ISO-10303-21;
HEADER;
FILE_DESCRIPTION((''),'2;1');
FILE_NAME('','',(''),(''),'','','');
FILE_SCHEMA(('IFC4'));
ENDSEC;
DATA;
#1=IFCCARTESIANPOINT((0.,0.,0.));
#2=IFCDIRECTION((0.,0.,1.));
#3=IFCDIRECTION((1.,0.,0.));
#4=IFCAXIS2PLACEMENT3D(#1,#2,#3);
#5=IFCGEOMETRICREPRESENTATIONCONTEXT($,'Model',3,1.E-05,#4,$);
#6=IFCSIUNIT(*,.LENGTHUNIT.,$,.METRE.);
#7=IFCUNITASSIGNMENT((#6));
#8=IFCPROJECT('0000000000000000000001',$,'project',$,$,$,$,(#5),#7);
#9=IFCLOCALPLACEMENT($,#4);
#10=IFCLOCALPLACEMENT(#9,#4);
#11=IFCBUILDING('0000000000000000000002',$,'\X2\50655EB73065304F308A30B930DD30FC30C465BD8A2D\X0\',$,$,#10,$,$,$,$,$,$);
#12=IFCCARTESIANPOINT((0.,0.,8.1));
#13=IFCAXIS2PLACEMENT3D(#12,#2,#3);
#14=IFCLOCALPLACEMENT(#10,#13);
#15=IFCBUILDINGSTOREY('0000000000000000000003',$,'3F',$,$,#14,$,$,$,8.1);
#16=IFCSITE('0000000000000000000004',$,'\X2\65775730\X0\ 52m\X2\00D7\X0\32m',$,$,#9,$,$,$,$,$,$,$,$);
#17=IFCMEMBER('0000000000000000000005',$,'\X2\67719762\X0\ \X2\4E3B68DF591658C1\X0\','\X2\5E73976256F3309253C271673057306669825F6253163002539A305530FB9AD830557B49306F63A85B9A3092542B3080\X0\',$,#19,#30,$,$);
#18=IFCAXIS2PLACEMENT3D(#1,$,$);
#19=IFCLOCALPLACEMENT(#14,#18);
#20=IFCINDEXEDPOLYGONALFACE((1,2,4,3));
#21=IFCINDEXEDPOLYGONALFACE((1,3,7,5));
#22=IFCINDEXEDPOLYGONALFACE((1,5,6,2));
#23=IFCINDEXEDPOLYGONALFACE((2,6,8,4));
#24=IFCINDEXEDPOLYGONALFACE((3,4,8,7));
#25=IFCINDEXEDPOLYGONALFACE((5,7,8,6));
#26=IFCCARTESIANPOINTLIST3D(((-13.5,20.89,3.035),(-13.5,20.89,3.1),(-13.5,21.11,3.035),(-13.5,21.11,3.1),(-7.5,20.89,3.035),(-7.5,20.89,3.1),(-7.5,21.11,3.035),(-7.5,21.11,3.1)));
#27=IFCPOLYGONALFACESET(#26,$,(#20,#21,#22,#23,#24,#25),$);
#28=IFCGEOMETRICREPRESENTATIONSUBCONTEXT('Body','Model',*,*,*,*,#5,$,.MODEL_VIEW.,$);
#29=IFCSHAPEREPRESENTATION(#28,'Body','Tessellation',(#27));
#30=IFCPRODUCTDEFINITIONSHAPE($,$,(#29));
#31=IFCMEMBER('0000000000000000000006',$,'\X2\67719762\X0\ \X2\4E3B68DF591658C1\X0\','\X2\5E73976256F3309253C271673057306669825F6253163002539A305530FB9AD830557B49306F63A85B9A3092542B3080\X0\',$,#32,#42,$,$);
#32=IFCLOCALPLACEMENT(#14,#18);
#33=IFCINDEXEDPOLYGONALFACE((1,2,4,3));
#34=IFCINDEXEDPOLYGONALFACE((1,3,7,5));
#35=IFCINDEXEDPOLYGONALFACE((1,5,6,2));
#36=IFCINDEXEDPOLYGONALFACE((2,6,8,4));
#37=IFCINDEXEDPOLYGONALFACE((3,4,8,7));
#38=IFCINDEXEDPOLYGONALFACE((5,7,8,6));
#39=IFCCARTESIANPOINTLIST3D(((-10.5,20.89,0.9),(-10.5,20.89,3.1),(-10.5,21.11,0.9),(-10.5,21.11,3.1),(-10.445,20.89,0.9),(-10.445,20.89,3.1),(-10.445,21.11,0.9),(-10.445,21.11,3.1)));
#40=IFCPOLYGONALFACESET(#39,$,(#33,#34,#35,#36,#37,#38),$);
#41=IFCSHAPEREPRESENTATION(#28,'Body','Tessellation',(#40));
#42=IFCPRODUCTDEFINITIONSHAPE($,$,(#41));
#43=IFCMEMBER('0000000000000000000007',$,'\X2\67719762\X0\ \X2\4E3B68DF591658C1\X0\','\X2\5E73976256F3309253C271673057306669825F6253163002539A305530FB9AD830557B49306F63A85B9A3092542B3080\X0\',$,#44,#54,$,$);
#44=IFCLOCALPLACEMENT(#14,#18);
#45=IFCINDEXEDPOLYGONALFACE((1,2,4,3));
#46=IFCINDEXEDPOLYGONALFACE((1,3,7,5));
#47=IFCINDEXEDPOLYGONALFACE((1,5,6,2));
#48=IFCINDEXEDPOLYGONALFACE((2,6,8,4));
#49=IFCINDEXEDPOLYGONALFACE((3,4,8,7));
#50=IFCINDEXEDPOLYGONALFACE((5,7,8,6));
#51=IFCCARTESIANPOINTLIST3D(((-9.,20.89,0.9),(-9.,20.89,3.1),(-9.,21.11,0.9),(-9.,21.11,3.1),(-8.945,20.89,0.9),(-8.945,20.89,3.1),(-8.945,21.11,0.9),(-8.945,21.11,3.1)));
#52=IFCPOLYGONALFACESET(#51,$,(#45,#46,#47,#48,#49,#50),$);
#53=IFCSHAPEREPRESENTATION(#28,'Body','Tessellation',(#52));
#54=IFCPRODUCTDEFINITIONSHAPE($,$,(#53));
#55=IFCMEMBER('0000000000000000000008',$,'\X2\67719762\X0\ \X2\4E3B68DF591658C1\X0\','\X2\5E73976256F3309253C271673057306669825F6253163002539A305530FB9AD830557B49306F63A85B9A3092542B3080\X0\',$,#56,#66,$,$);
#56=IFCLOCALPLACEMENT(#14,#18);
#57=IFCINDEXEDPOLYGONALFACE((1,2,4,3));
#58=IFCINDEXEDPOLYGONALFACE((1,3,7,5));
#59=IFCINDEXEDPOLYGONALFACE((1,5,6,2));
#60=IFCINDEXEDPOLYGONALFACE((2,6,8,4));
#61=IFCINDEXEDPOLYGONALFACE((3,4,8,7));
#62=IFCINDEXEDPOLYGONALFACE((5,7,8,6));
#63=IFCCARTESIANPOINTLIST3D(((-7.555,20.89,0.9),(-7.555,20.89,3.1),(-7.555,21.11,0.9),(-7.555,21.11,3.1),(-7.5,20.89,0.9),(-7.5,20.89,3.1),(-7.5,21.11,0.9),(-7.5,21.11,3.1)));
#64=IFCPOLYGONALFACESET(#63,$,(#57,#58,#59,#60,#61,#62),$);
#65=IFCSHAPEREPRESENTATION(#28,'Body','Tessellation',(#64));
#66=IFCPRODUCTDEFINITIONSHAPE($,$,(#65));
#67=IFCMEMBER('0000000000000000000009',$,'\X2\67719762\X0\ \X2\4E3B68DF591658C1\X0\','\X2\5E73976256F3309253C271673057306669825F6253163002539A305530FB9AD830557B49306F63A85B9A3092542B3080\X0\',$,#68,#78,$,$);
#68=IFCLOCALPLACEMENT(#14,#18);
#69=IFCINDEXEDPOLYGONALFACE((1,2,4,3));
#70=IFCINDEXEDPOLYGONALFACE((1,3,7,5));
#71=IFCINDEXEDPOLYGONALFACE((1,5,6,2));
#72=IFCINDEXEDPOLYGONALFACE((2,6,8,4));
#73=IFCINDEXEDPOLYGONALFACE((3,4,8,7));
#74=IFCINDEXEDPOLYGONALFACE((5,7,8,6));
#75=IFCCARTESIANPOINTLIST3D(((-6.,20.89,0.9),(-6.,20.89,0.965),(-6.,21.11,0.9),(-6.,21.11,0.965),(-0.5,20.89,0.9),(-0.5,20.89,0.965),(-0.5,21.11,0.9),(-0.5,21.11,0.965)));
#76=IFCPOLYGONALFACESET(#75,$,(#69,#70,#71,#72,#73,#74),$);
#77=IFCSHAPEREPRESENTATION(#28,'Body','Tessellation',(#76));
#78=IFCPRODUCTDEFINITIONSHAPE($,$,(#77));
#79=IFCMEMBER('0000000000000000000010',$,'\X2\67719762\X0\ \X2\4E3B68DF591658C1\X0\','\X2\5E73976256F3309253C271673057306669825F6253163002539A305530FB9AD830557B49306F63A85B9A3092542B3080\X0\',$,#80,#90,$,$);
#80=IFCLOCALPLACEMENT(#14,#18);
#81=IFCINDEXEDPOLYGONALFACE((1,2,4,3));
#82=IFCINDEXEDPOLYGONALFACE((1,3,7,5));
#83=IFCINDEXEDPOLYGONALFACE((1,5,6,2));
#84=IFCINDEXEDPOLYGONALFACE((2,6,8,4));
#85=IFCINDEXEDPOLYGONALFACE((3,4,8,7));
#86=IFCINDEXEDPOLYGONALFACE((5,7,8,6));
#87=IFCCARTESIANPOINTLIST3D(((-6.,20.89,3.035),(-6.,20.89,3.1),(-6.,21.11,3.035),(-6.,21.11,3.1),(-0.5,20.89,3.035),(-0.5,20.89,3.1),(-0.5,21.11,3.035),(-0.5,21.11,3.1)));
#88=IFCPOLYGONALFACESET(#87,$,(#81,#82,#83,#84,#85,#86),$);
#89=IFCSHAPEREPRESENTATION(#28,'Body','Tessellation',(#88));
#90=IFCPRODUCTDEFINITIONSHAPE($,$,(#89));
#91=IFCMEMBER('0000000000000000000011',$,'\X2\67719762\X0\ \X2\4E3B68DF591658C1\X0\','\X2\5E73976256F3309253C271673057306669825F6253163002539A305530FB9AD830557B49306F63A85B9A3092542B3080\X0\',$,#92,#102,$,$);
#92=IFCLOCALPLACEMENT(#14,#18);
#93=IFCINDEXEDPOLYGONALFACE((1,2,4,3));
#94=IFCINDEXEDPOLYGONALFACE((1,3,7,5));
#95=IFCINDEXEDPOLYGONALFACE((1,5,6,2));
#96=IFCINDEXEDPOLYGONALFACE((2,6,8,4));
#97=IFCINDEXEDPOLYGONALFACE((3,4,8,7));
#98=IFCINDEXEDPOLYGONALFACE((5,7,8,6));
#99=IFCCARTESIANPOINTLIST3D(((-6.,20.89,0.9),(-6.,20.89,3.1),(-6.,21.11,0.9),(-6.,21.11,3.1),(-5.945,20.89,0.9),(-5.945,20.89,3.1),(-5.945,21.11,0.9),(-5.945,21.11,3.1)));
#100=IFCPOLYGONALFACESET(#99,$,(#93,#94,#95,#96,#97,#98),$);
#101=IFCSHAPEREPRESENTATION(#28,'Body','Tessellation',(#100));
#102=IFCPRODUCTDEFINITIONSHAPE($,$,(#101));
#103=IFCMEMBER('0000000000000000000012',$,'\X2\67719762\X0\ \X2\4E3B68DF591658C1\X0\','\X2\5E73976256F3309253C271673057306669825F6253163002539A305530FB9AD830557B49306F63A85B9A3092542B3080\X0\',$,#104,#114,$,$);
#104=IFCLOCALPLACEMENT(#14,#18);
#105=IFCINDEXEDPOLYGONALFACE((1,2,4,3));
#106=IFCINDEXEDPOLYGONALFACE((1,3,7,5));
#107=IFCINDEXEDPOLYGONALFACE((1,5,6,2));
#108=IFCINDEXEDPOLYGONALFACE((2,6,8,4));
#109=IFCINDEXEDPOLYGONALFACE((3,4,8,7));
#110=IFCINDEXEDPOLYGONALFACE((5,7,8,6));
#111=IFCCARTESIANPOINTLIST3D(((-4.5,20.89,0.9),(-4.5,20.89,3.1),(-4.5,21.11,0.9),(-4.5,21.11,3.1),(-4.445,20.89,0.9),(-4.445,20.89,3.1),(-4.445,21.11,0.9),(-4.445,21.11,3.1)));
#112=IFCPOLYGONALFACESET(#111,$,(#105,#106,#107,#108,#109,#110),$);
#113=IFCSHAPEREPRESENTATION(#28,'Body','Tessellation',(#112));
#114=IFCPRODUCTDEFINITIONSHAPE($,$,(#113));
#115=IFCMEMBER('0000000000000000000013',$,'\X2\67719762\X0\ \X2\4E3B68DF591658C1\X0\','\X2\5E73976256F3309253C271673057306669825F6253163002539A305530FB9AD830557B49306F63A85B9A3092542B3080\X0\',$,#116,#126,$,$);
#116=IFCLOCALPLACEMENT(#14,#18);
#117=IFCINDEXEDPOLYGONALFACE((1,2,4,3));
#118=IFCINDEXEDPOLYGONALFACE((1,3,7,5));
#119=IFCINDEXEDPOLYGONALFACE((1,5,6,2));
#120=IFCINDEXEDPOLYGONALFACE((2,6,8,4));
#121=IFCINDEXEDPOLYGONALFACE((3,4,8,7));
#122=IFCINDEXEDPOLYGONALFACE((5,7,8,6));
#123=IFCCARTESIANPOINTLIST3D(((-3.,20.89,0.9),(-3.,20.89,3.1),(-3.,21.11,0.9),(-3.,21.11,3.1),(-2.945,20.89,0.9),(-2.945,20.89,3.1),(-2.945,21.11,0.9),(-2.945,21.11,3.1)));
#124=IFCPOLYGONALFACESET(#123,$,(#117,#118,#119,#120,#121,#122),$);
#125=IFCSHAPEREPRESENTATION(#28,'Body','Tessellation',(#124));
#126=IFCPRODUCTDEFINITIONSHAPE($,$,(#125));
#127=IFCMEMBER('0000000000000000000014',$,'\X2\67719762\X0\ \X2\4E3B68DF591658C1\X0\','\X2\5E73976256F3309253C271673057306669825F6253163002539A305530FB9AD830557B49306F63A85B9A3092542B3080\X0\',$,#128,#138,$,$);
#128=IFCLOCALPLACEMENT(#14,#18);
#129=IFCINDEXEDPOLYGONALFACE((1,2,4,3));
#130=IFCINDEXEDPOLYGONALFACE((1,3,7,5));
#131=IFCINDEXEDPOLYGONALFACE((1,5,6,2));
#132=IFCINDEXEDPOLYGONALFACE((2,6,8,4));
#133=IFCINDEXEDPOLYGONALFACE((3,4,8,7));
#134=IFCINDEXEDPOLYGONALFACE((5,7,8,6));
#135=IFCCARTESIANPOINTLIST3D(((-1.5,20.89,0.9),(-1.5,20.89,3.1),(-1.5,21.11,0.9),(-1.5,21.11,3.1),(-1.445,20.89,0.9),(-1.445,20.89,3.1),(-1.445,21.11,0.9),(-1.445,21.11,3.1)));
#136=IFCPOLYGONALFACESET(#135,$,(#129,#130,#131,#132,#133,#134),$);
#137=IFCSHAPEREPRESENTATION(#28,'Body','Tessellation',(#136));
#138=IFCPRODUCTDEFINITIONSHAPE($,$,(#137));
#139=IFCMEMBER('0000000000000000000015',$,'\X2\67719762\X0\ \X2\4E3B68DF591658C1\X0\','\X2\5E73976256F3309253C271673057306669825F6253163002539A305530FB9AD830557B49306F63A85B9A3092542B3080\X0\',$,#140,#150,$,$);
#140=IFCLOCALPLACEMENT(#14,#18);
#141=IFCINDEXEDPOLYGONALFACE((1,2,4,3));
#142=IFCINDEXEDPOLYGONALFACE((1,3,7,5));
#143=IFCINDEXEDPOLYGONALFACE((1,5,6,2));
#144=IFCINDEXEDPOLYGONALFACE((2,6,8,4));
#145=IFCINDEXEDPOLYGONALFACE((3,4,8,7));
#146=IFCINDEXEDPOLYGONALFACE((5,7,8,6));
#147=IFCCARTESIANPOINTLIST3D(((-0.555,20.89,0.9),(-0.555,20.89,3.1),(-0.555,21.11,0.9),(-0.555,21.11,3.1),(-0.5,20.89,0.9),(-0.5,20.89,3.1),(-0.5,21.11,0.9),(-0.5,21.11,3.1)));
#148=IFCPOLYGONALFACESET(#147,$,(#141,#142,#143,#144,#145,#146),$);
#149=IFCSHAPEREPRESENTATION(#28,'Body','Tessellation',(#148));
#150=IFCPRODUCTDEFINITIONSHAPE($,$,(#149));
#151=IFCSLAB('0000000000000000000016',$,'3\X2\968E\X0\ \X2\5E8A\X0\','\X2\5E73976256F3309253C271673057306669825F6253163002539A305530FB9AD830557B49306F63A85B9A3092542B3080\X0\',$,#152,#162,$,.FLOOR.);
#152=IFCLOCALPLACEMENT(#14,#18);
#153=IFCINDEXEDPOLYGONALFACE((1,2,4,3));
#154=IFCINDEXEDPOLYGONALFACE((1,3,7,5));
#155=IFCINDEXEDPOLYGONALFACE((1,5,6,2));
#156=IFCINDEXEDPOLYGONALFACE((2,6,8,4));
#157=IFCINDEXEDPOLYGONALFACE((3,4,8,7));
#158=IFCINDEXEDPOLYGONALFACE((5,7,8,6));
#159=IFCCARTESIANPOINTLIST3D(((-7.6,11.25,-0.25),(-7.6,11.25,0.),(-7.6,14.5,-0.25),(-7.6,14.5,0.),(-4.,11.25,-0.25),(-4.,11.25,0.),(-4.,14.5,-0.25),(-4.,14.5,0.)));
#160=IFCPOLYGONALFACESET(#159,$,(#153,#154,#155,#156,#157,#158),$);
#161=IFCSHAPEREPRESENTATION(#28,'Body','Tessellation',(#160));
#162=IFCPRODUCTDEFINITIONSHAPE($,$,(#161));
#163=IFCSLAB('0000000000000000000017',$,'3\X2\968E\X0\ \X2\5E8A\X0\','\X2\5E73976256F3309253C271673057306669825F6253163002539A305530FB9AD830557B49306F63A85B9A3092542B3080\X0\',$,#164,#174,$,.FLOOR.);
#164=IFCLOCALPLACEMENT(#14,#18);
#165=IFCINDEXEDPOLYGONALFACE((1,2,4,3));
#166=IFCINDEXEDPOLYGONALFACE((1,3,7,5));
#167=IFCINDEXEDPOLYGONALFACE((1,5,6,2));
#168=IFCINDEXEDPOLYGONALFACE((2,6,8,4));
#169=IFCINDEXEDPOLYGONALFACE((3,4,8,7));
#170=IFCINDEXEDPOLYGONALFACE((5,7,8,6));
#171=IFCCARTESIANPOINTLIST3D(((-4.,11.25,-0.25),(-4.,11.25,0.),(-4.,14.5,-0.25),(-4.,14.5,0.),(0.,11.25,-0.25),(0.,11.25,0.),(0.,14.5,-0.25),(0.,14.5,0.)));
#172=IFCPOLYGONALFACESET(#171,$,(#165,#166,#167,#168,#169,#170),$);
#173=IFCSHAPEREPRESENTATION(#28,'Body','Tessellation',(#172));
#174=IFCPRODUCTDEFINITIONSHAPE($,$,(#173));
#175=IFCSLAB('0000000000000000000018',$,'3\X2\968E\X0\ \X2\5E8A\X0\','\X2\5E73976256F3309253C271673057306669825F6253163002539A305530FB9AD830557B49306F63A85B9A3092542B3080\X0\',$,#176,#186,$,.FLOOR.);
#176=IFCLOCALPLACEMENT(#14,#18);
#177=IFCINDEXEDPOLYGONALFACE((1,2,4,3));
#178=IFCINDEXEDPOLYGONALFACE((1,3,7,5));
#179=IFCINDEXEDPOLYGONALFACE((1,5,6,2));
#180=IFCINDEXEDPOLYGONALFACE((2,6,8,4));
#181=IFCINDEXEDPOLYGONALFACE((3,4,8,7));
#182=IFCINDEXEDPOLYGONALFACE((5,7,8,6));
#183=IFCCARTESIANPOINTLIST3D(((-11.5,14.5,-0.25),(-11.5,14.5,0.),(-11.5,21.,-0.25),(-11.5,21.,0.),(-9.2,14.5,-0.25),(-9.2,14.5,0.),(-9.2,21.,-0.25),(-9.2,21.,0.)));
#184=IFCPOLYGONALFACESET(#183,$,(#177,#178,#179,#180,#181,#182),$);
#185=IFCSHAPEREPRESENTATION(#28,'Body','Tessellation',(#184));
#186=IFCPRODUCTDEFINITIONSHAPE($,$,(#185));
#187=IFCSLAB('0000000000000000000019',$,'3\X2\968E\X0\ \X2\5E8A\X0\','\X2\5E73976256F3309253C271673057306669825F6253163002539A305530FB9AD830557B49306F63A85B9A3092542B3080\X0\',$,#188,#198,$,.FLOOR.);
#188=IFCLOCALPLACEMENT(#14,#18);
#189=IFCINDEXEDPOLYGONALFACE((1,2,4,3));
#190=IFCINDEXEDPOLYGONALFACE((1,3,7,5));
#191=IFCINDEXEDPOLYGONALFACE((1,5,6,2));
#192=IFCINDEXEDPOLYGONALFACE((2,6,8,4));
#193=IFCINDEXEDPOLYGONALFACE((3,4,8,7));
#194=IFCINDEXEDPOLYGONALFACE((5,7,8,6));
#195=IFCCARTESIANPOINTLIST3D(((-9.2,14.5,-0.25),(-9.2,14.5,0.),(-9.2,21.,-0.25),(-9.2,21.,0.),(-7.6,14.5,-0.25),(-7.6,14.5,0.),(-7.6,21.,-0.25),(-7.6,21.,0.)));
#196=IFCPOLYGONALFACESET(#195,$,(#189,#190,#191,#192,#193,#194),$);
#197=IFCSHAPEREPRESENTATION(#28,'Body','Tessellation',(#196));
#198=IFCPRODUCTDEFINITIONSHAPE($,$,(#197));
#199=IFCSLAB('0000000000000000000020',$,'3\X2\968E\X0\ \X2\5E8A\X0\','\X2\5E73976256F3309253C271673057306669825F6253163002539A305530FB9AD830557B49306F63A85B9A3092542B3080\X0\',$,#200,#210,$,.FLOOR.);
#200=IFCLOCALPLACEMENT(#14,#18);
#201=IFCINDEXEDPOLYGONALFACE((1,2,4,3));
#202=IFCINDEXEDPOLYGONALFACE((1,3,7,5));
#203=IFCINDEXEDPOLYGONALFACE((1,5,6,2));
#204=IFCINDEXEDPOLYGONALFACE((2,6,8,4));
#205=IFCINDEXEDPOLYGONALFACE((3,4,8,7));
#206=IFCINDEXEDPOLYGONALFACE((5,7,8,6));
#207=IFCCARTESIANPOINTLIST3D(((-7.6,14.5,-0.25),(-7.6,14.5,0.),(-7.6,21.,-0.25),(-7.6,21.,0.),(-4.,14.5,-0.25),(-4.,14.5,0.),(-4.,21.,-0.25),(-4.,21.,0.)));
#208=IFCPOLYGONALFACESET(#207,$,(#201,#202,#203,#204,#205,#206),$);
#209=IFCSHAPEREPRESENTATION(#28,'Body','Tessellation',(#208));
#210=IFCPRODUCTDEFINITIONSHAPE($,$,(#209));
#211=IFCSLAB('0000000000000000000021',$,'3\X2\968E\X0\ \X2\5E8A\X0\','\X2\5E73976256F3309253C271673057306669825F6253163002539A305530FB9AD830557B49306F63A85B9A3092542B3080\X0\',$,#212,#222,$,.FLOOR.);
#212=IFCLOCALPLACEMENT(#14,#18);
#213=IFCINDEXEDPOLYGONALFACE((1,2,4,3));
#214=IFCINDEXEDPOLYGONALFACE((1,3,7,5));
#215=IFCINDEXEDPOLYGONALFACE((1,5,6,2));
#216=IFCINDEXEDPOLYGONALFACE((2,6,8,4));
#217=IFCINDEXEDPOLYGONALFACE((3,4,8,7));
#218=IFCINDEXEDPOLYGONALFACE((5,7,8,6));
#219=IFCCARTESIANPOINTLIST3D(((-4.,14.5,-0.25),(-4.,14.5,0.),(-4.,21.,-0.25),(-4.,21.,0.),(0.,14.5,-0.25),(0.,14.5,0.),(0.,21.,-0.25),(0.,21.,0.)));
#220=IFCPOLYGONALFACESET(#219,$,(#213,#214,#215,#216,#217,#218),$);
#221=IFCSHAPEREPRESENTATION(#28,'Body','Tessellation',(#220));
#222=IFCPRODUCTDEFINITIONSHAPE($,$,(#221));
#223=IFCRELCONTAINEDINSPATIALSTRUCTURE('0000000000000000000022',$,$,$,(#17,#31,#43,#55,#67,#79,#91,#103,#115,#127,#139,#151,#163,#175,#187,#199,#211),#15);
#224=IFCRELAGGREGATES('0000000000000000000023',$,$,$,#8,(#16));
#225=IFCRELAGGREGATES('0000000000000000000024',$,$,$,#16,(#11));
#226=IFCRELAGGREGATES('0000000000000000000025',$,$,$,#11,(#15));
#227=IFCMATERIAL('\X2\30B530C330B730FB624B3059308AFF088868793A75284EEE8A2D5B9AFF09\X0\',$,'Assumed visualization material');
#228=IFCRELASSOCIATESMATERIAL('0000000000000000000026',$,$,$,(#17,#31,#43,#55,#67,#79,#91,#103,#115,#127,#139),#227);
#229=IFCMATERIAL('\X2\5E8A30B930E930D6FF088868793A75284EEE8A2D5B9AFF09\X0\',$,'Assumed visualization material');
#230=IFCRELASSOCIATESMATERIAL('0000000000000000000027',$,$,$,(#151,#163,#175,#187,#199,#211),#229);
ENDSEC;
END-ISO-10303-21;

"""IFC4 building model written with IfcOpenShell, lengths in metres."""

from ifc_helpers import new_model, si_unit, frame, origin_with_axes, place, context, subcontext, project, spatial, rectangle, extrude, material, element, save


model = new_model("IFC4")

# Units and contexts
model_context = context("Model", 3, precision=1e-05, world=origin_with_axes())
body_context = subcontext(model_context, "Body", "Model", "MODEL_VIEW")
ifc_project = project(units=[si_unit("LENGTHUNIT", "METRE")], contexts=[model_context])

# Site, building, storey
site_placement = place(None, origin_with_axes())
site = spatial("IfcSite", under=ifc_project, at=site_placement, Name="敷地 52m×32m")
building_placement = place(site_placement, origin_with_axes())
building = spatial("IfcBuilding", under=site, at=building_placement, Name="健康づくりスポーツ施設")
storey_placement = place(building_placement, frame((0.0, 0.0, 8.1), z_axis=(0.0, 0.0, 1.0), x_axis=(1.0, 0.0, 0.0)))
storey = spatial("IfcBuildingStorey", under=building, at=storey_placement, Name="3F", Elevation=8.1)

# Members
ifc_material_1 = material(Name="サッシ・手すり（表示用仮設定）", Category="Assumed visualization material")
member_1_placement = place(storey_placement, frame((-10.5, 21.0, 3.035), z_axis=(0.0, 0.0, 1.0), x_axis=(1.0, 0.0, 0.0)))
element("IfcMember", 1, at=member_1_placement, inside=storey, material=ifc_material_1, Name="東面 主棟外壁", Description="平面図を参照して概形化。厚さ・高さ等は推定を含む", context=body_context, shape_type="SweptSolid", body=[
    extrude(rectangle(XDim=6.0, YDim=0.22), origin_with_axes(), (0.0, 0.0, 1.0), 0.065),
])
member_2_placement = place(storey_placement, frame((-10.4725, 21.0, 0.9), z_axis=(0.0, 0.0, 1.0), x_axis=(1.0, 0.0, 0.0)))
element("IfcMember", 2, at=member_2_placement, inside=storey, material=ifc_material_1, Name="東面 主棟外壁", Description="平面図を参照して概形化。厚さ・高さ等は推定を含む", context=body_context, shape_type="SweptSolid", body=[
    extrude(rectangle(XDim=0.055, YDim=0.22), origin_with_axes(), (0.0, 0.0, 1.0), 2.2),
])
for number, where, z_axis, x_axis, name in (
    (3, (-8.9725, 21.0, 0.9), (0.0, 0.0, 1.0), (1.0, 0.0, 0.0), "東面 主棟外壁"),
    (4, (-7.5275, 21.0, 0.9), (0.0, 0.0, 1.0), (1.0, 0.0, 0.0), "東面 主棟外壁"),
):
    element("IfcMember", number, at=place(storey_placement, frame(where, z_axis=z_axis, x_axis=x_axis)), inside=storey, material=ifc_material_1, Name=name, Description="平面図を参照して概形化。厚さ・高さ等は推定を含む", context=body_context, shape_type="SweptSolid", body=[
        extrude(rectangle(XDim=0.055, YDim=0.22), origin_with_axes(), (0.0, 0.0, 1.0), 2.2),
    ])
for number, where, z_axis, x_axis, name in (
    (5, (-3.25, 21.0, 0.9), (0.0, 0.0, 1.0), (1.0, 0.0, 0.0), "東面 主棟外壁"),
    (6, (-3.25, 21.0, 3.035), (0.0, 0.0, 1.0), (1.0, 0.0, 0.0), "東面 主棟外壁"),
):
    element("IfcMember", number, at=place(storey_placement, frame(where, z_axis=z_axis, x_axis=x_axis)), inside=storey, material=ifc_material_1, Name=name, Description="平面図を参照して概形化。厚さ・高さ等は推定を含む", context=body_context, shape_type="SweptSolid", body=[
        extrude(rectangle(XDim=5.5, YDim=0.22), origin_with_axes(), (0.0, 0.0, 1.0), 0.065),
    ])
for number, where, z_axis, x_axis, name in (
    (7, (-5.9725, 21.0, 0.9), (0.0, 0.0, 1.0), (1.0, 0.0, 0.0), "東面 主棟外壁"),
    (8, (-4.4725, 21.0, 0.9), (0.0, 0.0, 1.0), (1.0, 0.0, 0.0), "東面 主棟外壁"),
    (9, (-2.9725, 21.0, 0.9), (0.0, 0.0, 1.0), (1.0, 0.0, 0.0), "東面 主棟外壁"),
    (10, (-1.4725, 21.0, 0.9), (0.0, 0.0, 1.0), (1.0, 0.0, 0.0), "東面 主棟外壁"),
    (11, (-0.5275, 21.0, 0.9), (0.0, 0.0, 1.0), (1.0, 0.0, 0.0), "東面 主棟外壁"),
):
    element("IfcMember", number, at=place(storey_placement, frame(where, z_axis=z_axis, x_axis=x_axis)), inside=storey, material=ifc_material_1, Name=name, Description="平面図を参照して概形化。厚さ・高さ等は推定を含む", context=body_context, shape_type="SweptSolid", body=[
        extrude(rectangle(XDim=0.055, YDim=0.22), origin_with_axes(), (0.0, 0.0, 1.0), 2.2),
    ])

# Slabs
ifc_material_2 = material(Name="床スラブ（表示用仮設定）", Category="Assumed visualization material")
slab_1_placement = place(storey_placement, frame((-5.8, 12.875, -0.25), z_axis=(0.0, 0.0, 1.0), x_axis=(1.0, 0.0, 0.0)))
element("IfcSlab", 12, at=slab_1_placement, inside=storey, material=ifc_material_2, Name="3階 床", Description="平面図を参照して概形化。厚さ・高さ等は推定を含む", PredefinedType="FLOOR", context=body_context, shape_type="SweptSolid", body=[
    extrude(rectangle(XDim=3.6, YDim=3.25), origin_with_axes(), (0.0, 0.0, 1.0), 0.25),
])
slab_2_placement = place(storey_placement, frame((-2.0, 12.875, -0.25), z_axis=(0.0, 0.0, 1.0), x_axis=(1.0, 0.0, 0.0)))
element("IfcSlab", 13, at=slab_2_placement, inside=storey, material=ifc_material_2, Name="3階 床", Description="平面図を参照して概形化。厚さ・高さ等は推定を含む", PredefinedType="FLOOR", context=body_context, shape_type="SweptSolid", body=[
    extrude(rectangle(XDim=4.0, YDim=3.25), origin_with_axes(), (0.0, 0.0, 1.0), 0.25),
])
slab_3_placement = place(storey_placement, frame((-10.35, 17.75, -0.25), z_axis=(0.0, 0.0, 1.0), x_axis=(1.0, 0.0, 0.0)))
element("IfcSlab", 14, at=slab_3_placement, inside=storey, material=ifc_material_2, Name="3階 床", Description="平面図を参照して概形化。厚さ・高さ等は推定を含む", PredefinedType="FLOOR", context=body_context, shape_type="SweptSolid", body=[
    extrude(rectangle(XDim=2.3, YDim=6.5), origin_with_axes(), (0.0, 0.0, 1.0), 0.25),
])
slab_4_placement = place(storey_placement, frame((-8.4, 17.75, -0.25), z_axis=(0.0, 0.0, 1.0), x_axis=(1.0, 0.0, 0.0)))
element("IfcSlab", 15, at=slab_4_placement, inside=storey, material=ifc_material_2, Name="3階 床", Description="平面図を参照して概形化。厚さ・高さ等は推定を含む", PredefinedType="FLOOR", context=body_context, shape_type="SweptSolid", body=[
    extrude(rectangle(XDim=1.6, YDim=6.5), origin_with_axes(), (0.0, 0.0, 1.0), 0.25),
])
slab_5_placement = place(storey_placement, frame((-5.8, 17.75, -0.25), z_axis=(0.0, 0.0, 1.0), x_axis=(1.0, 0.0, 0.0)))
element("IfcSlab", 16, at=slab_5_placement, inside=storey, material=ifc_material_2, Name="3階 床", Description="平面図を参照して概形化。厚さ・高さ等は推定を含む", PredefinedType="FLOOR", context=body_context, shape_type="SweptSolid", body=[
    extrude(rectangle(XDim=3.6, YDim=6.5), origin_with_axes(), (0.0, 0.0, 1.0), 0.25),
])
slab_6_placement = place(storey_placement, frame((-2.0, 17.75, -0.25), z_axis=(0.0, 0.0, 1.0), x_axis=(1.0, 0.0, 0.0)))
element("IfcSlab", 17, at=slab_6_placement, inside=storey, material=ifc_material_2, Name="3階 床", Description="平面図を参照して概形化。厚さ・高さ等は推定を含む", PredefinedType="FLOOR", context=body_context, shape_type="SweptSolid", body=[
    extrude(rectangle(XDim=4.0, YDim=6.5), origin_with_axes(), (0.0, 0.0, 1.0), 0.25),
])

save(model, "model.ifc")
